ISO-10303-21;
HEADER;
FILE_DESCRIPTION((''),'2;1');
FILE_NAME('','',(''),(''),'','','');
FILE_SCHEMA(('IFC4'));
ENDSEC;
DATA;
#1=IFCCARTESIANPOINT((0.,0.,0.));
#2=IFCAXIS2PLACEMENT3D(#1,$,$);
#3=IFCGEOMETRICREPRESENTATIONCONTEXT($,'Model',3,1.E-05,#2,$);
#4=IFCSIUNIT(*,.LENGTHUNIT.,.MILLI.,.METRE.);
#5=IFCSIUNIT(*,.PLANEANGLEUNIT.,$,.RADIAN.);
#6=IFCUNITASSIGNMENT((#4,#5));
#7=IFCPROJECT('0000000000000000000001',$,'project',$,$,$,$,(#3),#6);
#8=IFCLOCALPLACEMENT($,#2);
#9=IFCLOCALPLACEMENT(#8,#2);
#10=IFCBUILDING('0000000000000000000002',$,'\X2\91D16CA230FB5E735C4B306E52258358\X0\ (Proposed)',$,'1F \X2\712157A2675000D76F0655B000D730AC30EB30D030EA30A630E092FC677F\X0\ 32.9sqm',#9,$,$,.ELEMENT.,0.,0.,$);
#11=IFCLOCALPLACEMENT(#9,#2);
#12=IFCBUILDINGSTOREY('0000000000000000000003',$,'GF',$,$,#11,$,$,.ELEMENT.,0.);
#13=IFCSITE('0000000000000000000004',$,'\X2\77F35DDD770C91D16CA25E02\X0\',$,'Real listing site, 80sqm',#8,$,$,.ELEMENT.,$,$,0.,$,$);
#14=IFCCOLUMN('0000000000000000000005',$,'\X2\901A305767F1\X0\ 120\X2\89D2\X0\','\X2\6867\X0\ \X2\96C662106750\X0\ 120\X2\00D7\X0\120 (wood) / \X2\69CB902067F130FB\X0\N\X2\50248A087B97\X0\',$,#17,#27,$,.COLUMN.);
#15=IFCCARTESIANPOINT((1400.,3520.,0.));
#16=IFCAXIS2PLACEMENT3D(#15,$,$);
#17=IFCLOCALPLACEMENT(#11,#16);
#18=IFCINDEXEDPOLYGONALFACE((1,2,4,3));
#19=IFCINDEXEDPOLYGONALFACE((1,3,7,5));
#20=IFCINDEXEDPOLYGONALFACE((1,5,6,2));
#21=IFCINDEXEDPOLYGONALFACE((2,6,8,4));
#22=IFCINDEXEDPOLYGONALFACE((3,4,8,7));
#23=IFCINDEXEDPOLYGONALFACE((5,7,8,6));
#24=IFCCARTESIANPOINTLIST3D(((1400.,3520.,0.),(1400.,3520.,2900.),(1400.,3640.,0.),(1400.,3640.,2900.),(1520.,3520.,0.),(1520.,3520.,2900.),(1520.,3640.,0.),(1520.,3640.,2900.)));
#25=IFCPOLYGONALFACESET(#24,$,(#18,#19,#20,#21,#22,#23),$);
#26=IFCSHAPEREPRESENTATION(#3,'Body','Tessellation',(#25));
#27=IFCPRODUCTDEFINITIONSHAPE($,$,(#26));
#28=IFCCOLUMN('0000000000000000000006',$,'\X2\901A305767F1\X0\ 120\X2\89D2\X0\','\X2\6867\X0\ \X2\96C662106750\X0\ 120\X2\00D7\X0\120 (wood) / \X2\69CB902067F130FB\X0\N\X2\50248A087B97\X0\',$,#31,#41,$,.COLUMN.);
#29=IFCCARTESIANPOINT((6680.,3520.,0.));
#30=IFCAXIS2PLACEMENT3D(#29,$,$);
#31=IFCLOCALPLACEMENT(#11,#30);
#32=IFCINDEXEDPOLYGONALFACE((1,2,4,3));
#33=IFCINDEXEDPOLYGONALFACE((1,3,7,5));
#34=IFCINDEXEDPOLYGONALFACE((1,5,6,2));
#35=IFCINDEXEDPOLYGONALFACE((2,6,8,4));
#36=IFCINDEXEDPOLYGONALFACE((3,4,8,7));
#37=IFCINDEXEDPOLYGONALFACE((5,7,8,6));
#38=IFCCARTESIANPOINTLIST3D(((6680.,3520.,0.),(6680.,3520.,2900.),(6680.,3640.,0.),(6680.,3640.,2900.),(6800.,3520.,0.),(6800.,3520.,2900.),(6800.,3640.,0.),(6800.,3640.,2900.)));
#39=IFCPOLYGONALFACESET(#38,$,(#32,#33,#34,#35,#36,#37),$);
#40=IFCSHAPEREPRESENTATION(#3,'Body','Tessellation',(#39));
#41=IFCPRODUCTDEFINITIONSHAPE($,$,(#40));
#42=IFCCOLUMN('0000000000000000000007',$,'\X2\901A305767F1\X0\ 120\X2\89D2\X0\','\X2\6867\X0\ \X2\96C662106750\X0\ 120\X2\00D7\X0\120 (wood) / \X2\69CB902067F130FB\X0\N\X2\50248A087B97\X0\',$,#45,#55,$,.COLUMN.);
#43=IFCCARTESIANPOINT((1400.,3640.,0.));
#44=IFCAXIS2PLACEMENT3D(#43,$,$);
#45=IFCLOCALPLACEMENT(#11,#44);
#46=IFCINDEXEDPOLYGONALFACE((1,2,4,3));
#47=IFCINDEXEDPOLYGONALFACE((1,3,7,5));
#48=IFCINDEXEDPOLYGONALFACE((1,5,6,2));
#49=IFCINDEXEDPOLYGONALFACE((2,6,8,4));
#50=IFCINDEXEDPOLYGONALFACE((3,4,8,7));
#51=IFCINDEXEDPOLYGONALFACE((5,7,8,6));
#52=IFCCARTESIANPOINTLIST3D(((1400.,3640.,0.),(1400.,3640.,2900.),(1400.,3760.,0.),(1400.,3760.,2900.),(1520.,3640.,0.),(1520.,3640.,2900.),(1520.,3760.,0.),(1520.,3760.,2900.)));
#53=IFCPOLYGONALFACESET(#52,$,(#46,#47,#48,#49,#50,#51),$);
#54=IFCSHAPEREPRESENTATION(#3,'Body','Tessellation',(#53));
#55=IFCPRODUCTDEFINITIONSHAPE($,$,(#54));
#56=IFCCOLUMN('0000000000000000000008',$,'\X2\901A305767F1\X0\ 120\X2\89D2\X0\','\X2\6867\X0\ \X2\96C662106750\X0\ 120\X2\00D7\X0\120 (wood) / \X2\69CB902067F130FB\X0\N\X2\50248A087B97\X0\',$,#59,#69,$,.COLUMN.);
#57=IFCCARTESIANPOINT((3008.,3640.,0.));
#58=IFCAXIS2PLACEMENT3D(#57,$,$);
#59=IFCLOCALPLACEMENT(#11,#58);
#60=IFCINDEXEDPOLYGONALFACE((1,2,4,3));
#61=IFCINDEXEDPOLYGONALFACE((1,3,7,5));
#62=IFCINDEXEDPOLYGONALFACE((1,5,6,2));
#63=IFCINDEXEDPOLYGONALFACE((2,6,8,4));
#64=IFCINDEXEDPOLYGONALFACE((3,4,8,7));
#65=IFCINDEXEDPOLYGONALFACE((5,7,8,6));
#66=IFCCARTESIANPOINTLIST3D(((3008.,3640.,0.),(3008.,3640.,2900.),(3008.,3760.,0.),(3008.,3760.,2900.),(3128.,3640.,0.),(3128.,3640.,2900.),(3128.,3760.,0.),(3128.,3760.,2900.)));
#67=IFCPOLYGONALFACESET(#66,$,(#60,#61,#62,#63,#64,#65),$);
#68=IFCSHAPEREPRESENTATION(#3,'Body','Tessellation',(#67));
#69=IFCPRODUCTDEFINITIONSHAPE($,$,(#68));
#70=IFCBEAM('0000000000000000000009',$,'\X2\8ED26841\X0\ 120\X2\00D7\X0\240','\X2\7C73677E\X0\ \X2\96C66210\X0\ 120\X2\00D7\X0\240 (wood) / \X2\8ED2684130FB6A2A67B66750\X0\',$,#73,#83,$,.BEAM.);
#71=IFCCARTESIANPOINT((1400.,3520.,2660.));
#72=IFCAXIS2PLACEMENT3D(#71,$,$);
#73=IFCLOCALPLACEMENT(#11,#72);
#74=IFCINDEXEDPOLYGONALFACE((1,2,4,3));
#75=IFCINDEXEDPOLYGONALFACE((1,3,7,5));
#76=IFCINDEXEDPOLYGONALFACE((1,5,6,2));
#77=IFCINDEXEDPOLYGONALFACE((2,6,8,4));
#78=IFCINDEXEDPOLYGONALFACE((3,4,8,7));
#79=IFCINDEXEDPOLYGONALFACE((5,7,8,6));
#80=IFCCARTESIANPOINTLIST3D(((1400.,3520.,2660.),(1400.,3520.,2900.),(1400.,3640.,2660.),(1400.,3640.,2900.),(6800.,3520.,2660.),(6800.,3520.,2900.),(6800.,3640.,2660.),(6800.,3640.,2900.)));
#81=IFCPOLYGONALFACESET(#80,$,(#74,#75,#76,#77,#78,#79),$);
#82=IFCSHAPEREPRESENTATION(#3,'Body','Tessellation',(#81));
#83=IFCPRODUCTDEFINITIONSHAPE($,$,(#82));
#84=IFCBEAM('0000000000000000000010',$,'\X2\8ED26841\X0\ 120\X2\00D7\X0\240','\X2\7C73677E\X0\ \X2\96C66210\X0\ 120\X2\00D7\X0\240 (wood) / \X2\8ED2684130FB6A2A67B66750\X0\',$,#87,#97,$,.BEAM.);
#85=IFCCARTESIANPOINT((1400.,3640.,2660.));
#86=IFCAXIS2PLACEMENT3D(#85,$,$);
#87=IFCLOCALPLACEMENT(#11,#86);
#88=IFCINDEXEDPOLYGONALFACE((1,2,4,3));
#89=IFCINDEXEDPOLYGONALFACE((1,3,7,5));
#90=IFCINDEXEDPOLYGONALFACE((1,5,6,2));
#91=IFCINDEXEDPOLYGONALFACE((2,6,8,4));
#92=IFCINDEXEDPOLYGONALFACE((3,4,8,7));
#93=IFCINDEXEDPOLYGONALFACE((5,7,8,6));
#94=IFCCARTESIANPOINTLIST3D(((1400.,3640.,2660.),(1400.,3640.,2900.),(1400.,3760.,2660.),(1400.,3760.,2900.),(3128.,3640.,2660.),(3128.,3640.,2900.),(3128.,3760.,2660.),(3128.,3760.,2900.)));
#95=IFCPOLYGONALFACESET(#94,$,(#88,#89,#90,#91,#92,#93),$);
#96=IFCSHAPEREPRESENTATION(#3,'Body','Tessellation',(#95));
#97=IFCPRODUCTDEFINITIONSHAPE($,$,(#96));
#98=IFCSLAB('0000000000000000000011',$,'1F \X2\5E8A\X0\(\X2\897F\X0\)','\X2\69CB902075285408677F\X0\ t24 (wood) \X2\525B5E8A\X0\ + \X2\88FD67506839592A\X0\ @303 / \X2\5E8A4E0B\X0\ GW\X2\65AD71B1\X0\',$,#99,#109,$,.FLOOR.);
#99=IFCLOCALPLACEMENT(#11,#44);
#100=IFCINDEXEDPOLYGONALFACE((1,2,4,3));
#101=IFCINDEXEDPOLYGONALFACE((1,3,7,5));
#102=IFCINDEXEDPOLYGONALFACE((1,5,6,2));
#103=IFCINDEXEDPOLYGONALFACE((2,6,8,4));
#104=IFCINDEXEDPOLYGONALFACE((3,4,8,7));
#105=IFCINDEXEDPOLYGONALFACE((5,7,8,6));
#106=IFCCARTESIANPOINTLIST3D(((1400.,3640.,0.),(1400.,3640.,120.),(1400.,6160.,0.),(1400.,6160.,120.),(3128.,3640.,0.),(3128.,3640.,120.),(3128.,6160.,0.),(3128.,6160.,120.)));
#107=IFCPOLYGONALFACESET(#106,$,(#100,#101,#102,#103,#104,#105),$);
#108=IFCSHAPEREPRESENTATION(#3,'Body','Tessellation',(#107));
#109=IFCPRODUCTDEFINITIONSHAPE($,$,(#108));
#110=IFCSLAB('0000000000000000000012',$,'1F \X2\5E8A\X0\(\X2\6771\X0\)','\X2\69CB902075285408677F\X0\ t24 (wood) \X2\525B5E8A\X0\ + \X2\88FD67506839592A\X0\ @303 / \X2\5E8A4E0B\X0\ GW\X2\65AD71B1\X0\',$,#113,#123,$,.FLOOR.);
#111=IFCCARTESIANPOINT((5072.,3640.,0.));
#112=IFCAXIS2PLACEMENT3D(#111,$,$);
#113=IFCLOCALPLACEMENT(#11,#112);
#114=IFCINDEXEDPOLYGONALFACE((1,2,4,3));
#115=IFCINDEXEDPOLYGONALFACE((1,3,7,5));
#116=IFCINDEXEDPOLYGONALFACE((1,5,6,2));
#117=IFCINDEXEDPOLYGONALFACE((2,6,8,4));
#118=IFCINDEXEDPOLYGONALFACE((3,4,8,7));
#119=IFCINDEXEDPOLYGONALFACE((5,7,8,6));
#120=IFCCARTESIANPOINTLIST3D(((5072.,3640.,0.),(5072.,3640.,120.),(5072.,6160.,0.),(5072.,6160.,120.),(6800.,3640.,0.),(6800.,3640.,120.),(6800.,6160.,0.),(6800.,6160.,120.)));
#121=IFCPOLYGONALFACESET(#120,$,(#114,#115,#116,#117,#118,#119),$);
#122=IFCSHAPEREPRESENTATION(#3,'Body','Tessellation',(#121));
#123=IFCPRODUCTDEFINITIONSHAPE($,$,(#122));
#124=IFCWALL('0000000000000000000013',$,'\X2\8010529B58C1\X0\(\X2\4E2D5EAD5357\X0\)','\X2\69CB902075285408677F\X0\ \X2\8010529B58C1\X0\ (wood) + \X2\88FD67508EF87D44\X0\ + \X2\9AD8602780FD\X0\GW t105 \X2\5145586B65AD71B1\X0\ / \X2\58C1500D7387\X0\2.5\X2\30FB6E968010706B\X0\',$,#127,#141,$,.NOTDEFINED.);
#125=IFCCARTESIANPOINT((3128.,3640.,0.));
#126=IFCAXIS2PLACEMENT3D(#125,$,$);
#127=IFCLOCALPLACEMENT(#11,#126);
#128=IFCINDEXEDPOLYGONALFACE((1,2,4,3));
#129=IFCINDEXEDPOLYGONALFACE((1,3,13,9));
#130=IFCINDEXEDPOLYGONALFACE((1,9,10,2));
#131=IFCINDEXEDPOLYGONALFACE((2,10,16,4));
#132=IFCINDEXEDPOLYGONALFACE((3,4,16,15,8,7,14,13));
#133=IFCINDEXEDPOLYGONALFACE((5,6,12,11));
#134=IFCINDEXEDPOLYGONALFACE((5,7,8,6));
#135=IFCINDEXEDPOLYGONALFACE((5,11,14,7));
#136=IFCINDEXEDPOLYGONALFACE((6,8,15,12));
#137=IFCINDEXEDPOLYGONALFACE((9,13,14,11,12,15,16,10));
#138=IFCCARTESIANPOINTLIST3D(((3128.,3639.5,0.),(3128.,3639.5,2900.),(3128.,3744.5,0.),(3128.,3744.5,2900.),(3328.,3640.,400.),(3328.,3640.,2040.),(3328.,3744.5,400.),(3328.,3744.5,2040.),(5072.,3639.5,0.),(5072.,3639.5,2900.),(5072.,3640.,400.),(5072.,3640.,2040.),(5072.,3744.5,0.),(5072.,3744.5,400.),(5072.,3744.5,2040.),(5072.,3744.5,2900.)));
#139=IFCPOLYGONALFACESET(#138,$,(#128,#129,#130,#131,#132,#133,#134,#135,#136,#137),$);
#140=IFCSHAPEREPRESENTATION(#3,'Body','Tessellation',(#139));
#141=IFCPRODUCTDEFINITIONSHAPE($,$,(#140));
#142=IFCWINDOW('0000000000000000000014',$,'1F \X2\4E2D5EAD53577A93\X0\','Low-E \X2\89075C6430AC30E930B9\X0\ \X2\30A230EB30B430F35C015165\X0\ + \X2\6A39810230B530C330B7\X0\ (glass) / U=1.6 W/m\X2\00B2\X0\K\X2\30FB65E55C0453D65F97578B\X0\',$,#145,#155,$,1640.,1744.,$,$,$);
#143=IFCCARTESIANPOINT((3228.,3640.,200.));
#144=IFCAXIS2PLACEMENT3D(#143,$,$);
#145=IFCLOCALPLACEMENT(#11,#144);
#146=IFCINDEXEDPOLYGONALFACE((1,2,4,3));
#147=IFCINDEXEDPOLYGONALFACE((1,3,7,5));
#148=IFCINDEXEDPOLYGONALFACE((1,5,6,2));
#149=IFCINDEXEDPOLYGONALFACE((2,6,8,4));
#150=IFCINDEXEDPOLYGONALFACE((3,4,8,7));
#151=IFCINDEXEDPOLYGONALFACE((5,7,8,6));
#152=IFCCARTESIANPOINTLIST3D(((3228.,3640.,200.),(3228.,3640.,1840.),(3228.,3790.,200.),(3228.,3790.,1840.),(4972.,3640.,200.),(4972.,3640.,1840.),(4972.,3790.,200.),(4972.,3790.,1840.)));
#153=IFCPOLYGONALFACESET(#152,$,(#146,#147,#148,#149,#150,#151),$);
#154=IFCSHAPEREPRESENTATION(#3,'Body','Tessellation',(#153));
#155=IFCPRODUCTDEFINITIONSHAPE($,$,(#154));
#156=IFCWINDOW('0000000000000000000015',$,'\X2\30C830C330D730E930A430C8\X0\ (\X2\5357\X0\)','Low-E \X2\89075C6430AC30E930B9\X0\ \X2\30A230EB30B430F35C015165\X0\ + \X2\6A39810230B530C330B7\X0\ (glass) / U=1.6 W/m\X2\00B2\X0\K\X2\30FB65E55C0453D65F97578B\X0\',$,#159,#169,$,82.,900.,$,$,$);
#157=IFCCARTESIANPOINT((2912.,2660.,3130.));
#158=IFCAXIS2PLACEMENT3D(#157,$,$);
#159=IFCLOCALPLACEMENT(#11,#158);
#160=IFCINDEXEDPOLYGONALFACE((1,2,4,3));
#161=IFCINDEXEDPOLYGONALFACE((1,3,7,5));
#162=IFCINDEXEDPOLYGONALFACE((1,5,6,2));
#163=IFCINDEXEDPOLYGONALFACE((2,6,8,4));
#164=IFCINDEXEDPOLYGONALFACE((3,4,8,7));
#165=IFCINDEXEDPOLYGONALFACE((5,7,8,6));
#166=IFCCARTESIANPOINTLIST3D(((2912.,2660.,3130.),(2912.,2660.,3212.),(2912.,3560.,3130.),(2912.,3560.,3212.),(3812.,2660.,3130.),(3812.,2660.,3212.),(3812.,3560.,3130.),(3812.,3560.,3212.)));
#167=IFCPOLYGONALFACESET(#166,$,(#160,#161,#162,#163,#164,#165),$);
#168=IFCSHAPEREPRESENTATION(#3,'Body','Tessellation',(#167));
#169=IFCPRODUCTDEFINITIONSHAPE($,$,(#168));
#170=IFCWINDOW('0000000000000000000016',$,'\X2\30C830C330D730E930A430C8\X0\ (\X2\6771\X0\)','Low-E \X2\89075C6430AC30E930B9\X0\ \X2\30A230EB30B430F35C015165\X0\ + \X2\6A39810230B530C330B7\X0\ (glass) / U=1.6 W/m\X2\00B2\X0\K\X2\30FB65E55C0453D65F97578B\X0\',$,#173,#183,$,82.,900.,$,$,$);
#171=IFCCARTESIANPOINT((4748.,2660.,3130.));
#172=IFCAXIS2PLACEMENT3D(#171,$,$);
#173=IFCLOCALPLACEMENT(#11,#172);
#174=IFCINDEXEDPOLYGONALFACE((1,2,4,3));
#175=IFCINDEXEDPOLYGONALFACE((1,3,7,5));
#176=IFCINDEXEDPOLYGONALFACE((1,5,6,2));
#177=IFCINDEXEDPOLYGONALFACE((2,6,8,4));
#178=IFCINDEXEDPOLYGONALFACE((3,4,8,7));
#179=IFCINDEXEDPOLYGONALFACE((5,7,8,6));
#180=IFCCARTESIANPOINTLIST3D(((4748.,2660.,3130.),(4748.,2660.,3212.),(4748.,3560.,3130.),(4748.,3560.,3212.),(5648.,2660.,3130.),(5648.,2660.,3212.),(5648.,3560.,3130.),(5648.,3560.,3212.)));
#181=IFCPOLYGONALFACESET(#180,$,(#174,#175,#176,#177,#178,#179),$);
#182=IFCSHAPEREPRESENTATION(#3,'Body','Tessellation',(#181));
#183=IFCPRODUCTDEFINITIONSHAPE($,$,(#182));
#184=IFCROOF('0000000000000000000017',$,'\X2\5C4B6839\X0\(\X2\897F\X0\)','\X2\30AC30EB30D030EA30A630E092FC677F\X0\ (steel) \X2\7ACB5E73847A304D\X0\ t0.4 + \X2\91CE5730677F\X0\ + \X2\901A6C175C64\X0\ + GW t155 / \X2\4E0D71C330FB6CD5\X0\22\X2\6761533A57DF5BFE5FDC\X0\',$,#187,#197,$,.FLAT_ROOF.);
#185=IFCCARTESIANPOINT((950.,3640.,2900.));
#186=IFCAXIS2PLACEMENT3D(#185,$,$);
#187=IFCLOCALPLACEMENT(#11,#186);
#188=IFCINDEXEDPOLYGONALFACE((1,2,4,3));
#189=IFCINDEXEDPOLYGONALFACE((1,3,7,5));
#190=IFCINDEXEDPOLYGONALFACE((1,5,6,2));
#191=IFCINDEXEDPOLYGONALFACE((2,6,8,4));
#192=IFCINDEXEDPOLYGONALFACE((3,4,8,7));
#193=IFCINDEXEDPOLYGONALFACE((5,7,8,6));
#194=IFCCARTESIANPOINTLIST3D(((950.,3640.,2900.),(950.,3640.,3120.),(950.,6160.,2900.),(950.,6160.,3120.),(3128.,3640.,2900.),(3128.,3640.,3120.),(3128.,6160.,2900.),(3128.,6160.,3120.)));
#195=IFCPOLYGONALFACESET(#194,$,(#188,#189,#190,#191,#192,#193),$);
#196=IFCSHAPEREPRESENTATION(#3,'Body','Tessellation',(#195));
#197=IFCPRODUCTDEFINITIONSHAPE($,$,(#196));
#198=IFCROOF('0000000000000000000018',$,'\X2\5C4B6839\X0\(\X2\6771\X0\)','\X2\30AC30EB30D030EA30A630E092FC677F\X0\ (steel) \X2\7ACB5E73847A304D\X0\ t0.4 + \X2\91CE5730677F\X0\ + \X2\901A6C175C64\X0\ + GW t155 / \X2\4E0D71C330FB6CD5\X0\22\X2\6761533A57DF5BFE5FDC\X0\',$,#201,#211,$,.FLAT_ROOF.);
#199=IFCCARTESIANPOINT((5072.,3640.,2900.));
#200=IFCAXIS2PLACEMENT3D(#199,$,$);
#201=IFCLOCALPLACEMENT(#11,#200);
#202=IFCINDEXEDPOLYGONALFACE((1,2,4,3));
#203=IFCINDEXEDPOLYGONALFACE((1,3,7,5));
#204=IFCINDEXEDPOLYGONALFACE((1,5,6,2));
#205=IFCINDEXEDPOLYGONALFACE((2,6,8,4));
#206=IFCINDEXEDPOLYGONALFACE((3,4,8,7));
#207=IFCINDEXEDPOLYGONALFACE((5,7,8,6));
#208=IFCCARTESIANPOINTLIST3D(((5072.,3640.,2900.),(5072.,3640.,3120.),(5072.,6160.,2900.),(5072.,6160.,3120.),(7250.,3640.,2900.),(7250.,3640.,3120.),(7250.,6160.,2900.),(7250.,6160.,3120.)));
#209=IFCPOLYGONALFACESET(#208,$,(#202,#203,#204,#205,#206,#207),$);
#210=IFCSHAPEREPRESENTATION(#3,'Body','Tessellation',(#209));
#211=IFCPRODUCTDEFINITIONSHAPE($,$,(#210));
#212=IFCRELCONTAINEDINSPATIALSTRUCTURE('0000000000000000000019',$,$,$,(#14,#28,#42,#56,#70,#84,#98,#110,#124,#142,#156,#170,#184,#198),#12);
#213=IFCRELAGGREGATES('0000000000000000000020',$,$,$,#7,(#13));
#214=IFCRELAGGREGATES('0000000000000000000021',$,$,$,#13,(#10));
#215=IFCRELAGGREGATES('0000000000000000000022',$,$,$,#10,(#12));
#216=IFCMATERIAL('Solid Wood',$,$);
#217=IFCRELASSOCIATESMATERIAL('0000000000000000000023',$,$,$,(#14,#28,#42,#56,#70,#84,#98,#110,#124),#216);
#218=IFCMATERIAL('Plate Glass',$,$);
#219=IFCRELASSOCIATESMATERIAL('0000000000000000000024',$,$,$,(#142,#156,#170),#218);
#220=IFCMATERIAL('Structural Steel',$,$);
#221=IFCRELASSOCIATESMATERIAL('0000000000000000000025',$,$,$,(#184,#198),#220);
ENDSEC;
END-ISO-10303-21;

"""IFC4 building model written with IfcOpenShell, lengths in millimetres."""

from ifc_helpers import new_model, si_unit, frame, frame_2d, origin, place, context, project, spatial, rectangle, extrude, material, element, fill, save


model = new_model("IFC4")

# Units and contexts
model_context = context("Model", 3, precision=1e-05, world=origin())
ifc_project = project(units=[si_unit("LENGTHUNIT", "METRE", prefix="MILLI"), si_unit("PLANEANGLEUNIT", "RADIAN")], contexts=[model_context])

# Site, building, storey
site_placement = place(None, origin())
site = spatial("IfcSite", under=ifc_project, at=site_placement, Name="石川県金沢市", ObjectType="Real listing site, 80sqm", CompositionType="ELEMENT", RefElevation=0.0)
building_placement = place(site_placement, origin())
building = spatial("IfcBuilding", under=site, at=building_placement, Name="金沢・平屋の別荘 (Proposed)", ObjectType="1F 無垢材×漆喰×ガルバリウム鋼板 32.9sqm", CompositionType="ELEMENT", ElevationOfRefHeight=0.0, ElevationOfTerrain=0.0)
storey_placement = place(building_placement, origin())
storey = spatial("IfcBuildingStorey", under=building, at=storey_placement, Name="GF", CompositionType="ELEMENT", Elevation=0.0)

# Columns
ifc_material_1 = material(Name="Solid Wood")
column_1_placement = place(storey_placement, frame((1400.0, 3520.0, 0.0)))
element("IfcColumn", 1, at=column_1_placement, inside=storey, material=ifc_material_1, Name="通し柱 120角", Description="桧 集成材 120×120 (wood) / 構造柱・N値計算", PredefinedType="COLUMN", context=model_context, shape_type="SweptSolid", body=[
    extrude(rectangle(XDim=120.0, YDim=120.0, at=frame_2d((60.0, 60.0))), frame((1400.0, 3520.0, 0.0)), (0.0, 0.0, 1.0), 2900.0),
])
column_2_placement = place(storey_placement, frame((6680.0, 3520.0, 0.0)))
element("IfcColumn", 2, at=column_2_placement, inside=storey, material=ifc_material_1, Name="通し柱 120角", Description="桧 集成材 120×120 (wood) / 構造柱・N値計算", PredefinedType="COLUMN", context=model_context, shape_type="SweptSolid", body=[
    extrude(rectangle(XDim=120.0, YDim=120.0, at=frame_2d((60.0, 60.0))), frame((6680.0, 3520.0, 0.0)), (0.0, 0.0, 1.0), 2900.0),
])
column_3_placement = place(storey_placement, frame((1400.0, 3640.0, 0.0)))
element("IfcColumn", 3, at=column_3_placement, inside=storey, material=ifc_material_1, Name="通し柱 120角", Description="桧 集成材 120×120 (wood) / 構造柱・N値計算", PredefinedType="COLUMN", context=model_context, shape_type="SweptSolid", body=[
    extrude(rectangle(XDim=120.0, YDim=120.0, at=frame_2d((60.0, 60.0))), frame((1400.0, 3640.0, 0.0)), (0.0, 0.0, 1.0), 2900.0),
])
column_4_placement = place(storey_placement, frame((3008.0, 3640.0, 0.0)))
element("IfcColumn", 4, at=column_4_placement, inside=storey, material=ifc_material_1, Name="通し柱 120角", Description="桧 集成材 120×120 (wood) / 構造柱・N値計算", PredefinedType="COLUMN", context=model_context, shape_type="SweptSolid", body=[
    extrude(rectangle(XDim=120.0, YDim=120.0, at=frame_2d((60.0, 60.0))), frame((3008.0, 3640.0, 0.0)), (0.0, 0.0, 1.0), 2900.0),
])

# Beams
beam_1_placement = place(storey_placement, frame((1400.0, 3520.0, 2660.0)))
element("IfcBeam", 5, at=beam_1_placement, inside=storey, material=ifc_material_1, Name="軒桁 120×240", Description="米松 集成 120×240 (wood) / 軒桁・横架材", PredefinedType="BEAM", context=model_context, shape_type="SweptSolid", body=[
    extrude(rectangle(XDim=5400.0, YDim=120.0, at=frame_2d((2700.0, 60.0))), frame((1400.0, 3520.0, 2660.0)), (0.0, 0.0, 1.0), 240.0),
])
beam_2_placement = place(storey_placement, frame((1400.0, 3640.0, 2660.0)))
element("IfcBeam", 6, at=beam_2_placement, inside=storey, material=ifc_material_1, Name="軒桁 120×240", Description="米松 集成 120×240 (wood) / 軒桁・横架材", PredefinedType="BEAM", context=model_context, shape_type="SweptSolid", body=[
    extrude(rectangle(XDim=1728.0, YDim=120.0, at=frame_2d((864.0, 60.0))), frame((1400.0, 3640.0, 2660.0)), (0.0, 0.0, 1.0), 240.0),
])

# Slabs
slab_1_placement = place(storey_placement, frame((1400.0, 3640.0, 0.0)))
element("IfcSlab", 7, at=slab_1_placement, inside=storey, material=ifc_material_1, Name="1F 床(西)", Description="構造用合板 t24 (wood) 剛床 + 製材根太 @303 / 床下 GW断熱", PredefinedType="FLOOR", context=model_context, shape_type="SweptSolid", body=[
    extrude(rectangle(XDim=1728.0, YDim=2520.0, at=frame_2d((864.0, 1260.0))), frame((1400.0, 3640.0, 0.0)), (0.0, 0.0, 1.0), 120.0),
])
slab_2_placement = place(storey_placement, frame((5072.0, 3640.0, 0.0)))
element("IfcSlab", 8, at=slab_2_placement, inside=storey, material=ifc_material_1, Name="1F 床(東)", Description="構造用合板 t24 (wood) 剛床 + 製材根太 @303 / 床下 GW断熱", PredefinedType="FLOOR", context=model_context, shape_type="SweptSolid", body=[
    extrude(rectangle(XDim=1728.0, YDim=2520.0, at=frame_2d((864.0, 1260.0))), frame((5072.0, 3640.0, 0.0)), (0.0, 0.0, 1.0), 120.0),
])

# Wall, opening, window
wall_1_placement = place(storey_placement, frame((3128.0, 3640.0, 0.0)))
wall_1 = element("IfcWall", 9, at=wall_1_placement, inside=storey, material=ifc_material_1, Name="耐力壁(中庭南)", Description="構造用合板 耐力壁 (wood) + 製材軸組 + 高性能GW t105 充填断熱 / 壁倍率2.5・準耐火", PredefinedType="NOTDEFINED", context=model_context, shape_type="SweptSolid", body=[
    extrude(rectangle(XDim=1944.0, YDim=105.0, at=frame_2d((972.0, 52.0))), frame((3128.0, 3640.0, 0.0)), (0.0, 0.0, 1.0), 2900.0),
])
opening_placement = place(storey_placement, frame((3228.0, 3640.0, 200.0)))
opening = element("IfcOpeningElement", 10, at=opening_placement, cuts=wall_1, PredefinedType="NOTDEFINED", context=model_context, shape_type="SweptSolid", body=[
    extrude(rectangle(XDim=1744.0, YDim=150.0, at=frame_2d((872.0, 75.0))), frame((3228.0, 3640.0, 200.0)), (0.0, 0.0, 1.0), 1640.0),
])
ifc_material_2 = material(Name="Plate Glass")
window_1_placement = place(storey_placement, frame((3228.0, 3640.0, 200.0)))
window_1 = element("IfcWindow", 11, at=window_1_placement, inside=storey, material=ifc_material_2, Name="1F 中庭南窓", Description="Low-E 複層ガラス アルゴン封入 + 樹脂サッシ (glass) / U=1.6 W/m²K・日射取得型", OverallHeight=1640.0, OverallWidth=1744.0, context=model_context, shape_type="SweptSolid", body=[
    extrude(rectangle(XDim=1744.0, YDim=150.0, at=frame_2d((872.0, 75.0))), frame((3228.0, 3640.0, 200.0)), (0.0, 0.0, 1.0), 1640.0),
])
fill(opening, window_1)

# Windows
window_2_placement = place(storey_placement, frame((2912.0, 2660.0, 3130.0)))
element("IfcWindow", 12, at=window_2_placement, inside=storey, material=ifc_material_2, Name="トップライト (南)", Description="Low-E 複層ガラス アルゴン封入 + 樹脂サッシ (glass) / U=1.6 W/m²K・日射取得型", OverallHeight=82.0, OverallWidth=900.0, context=model_context, shape_type="SweptSolid", body=[
    extrude(rectangle(XDim=900.0, YDim=900.0, at=frame_2d((450.0, 450.0))), frame((2912.0, 2660.0, 3130.0)), (0.0, 0.0, 1.0), 82.0),
])
window_3_placement = place(storey_placement, frame((4748.0, 2660.0, 3130.0)))
element("IfcWindow", 13, at=window_3_placement, inside=storey, material=ifc_material_2, Name="トップライト (東)", Description="Low-E 複層ガラス アルゴン封入 + 樹脂サッシ (glass) / U=1.6 W/m²K・日射取得型", OverallHeight=82.0, OverallWidth=900.0, context=model_context, shape_type="SweptSolid", body=[
    extrude(rectangle(XDim=900.0, YDim=900.0, at=frame_2d((450.0, 450.0))), frame((4748.0, 2660.0, 3130.0)), (0.0, 0.0, 1.0), 82.0),
])

# Roofs
ifc_material_3 = material(Name="Structural Steel")
roof_1_placement = place(storey_placement, frame((950.0, 3640.0, 2900.0)))
element("IfcRoof", 14, at=roof_1_placement, inside=storey, material=ifc_material_3, Name="屋根(西)", Description="ガルバリウム鋼板 (steel) 立平葺き t0.4 + 野地板 + 通気層 + GW t155 / 不燃・法22条区域対応", PredefinedType="FLAT_ROOF", context=model_context, shape_type="SweptSolid", body=[
    extrude(rectangle(XDim=2178.0, YDim=2520.0, at=frame_2d((1089.0, 1260.0))), frame((950.0, 3640.0, 2900.0)), (0.0, 0.0, 1.0), 220.0),
])
roof_2_placement = place(storey_placement, frame((5072.0, 3640.0, 2900.0)))
element("IfcRoof", 15, at=roof_2_placement, inside=storey, material=ifc_material_3, Name="屋根(東)", Description="ガルバリウム鋼板 (steel) 立平葺き t0.4 + 野地板 + 通気層 + GW t155 / 不燃・法22条区域対応", PredefinedType="FLAT_ROOF", context=model_context, shape_type="SweptSolid", body=[
    extrude(rectangle(XDim=2178.0, YDim=2520.0, at=frame_2d((1089.0, 1260.0))), frame((5072.0, 3640.0, 2900.0)), (0.0, 0.0, 1.0), 220.0),
])

save(model, "model.ifc")
